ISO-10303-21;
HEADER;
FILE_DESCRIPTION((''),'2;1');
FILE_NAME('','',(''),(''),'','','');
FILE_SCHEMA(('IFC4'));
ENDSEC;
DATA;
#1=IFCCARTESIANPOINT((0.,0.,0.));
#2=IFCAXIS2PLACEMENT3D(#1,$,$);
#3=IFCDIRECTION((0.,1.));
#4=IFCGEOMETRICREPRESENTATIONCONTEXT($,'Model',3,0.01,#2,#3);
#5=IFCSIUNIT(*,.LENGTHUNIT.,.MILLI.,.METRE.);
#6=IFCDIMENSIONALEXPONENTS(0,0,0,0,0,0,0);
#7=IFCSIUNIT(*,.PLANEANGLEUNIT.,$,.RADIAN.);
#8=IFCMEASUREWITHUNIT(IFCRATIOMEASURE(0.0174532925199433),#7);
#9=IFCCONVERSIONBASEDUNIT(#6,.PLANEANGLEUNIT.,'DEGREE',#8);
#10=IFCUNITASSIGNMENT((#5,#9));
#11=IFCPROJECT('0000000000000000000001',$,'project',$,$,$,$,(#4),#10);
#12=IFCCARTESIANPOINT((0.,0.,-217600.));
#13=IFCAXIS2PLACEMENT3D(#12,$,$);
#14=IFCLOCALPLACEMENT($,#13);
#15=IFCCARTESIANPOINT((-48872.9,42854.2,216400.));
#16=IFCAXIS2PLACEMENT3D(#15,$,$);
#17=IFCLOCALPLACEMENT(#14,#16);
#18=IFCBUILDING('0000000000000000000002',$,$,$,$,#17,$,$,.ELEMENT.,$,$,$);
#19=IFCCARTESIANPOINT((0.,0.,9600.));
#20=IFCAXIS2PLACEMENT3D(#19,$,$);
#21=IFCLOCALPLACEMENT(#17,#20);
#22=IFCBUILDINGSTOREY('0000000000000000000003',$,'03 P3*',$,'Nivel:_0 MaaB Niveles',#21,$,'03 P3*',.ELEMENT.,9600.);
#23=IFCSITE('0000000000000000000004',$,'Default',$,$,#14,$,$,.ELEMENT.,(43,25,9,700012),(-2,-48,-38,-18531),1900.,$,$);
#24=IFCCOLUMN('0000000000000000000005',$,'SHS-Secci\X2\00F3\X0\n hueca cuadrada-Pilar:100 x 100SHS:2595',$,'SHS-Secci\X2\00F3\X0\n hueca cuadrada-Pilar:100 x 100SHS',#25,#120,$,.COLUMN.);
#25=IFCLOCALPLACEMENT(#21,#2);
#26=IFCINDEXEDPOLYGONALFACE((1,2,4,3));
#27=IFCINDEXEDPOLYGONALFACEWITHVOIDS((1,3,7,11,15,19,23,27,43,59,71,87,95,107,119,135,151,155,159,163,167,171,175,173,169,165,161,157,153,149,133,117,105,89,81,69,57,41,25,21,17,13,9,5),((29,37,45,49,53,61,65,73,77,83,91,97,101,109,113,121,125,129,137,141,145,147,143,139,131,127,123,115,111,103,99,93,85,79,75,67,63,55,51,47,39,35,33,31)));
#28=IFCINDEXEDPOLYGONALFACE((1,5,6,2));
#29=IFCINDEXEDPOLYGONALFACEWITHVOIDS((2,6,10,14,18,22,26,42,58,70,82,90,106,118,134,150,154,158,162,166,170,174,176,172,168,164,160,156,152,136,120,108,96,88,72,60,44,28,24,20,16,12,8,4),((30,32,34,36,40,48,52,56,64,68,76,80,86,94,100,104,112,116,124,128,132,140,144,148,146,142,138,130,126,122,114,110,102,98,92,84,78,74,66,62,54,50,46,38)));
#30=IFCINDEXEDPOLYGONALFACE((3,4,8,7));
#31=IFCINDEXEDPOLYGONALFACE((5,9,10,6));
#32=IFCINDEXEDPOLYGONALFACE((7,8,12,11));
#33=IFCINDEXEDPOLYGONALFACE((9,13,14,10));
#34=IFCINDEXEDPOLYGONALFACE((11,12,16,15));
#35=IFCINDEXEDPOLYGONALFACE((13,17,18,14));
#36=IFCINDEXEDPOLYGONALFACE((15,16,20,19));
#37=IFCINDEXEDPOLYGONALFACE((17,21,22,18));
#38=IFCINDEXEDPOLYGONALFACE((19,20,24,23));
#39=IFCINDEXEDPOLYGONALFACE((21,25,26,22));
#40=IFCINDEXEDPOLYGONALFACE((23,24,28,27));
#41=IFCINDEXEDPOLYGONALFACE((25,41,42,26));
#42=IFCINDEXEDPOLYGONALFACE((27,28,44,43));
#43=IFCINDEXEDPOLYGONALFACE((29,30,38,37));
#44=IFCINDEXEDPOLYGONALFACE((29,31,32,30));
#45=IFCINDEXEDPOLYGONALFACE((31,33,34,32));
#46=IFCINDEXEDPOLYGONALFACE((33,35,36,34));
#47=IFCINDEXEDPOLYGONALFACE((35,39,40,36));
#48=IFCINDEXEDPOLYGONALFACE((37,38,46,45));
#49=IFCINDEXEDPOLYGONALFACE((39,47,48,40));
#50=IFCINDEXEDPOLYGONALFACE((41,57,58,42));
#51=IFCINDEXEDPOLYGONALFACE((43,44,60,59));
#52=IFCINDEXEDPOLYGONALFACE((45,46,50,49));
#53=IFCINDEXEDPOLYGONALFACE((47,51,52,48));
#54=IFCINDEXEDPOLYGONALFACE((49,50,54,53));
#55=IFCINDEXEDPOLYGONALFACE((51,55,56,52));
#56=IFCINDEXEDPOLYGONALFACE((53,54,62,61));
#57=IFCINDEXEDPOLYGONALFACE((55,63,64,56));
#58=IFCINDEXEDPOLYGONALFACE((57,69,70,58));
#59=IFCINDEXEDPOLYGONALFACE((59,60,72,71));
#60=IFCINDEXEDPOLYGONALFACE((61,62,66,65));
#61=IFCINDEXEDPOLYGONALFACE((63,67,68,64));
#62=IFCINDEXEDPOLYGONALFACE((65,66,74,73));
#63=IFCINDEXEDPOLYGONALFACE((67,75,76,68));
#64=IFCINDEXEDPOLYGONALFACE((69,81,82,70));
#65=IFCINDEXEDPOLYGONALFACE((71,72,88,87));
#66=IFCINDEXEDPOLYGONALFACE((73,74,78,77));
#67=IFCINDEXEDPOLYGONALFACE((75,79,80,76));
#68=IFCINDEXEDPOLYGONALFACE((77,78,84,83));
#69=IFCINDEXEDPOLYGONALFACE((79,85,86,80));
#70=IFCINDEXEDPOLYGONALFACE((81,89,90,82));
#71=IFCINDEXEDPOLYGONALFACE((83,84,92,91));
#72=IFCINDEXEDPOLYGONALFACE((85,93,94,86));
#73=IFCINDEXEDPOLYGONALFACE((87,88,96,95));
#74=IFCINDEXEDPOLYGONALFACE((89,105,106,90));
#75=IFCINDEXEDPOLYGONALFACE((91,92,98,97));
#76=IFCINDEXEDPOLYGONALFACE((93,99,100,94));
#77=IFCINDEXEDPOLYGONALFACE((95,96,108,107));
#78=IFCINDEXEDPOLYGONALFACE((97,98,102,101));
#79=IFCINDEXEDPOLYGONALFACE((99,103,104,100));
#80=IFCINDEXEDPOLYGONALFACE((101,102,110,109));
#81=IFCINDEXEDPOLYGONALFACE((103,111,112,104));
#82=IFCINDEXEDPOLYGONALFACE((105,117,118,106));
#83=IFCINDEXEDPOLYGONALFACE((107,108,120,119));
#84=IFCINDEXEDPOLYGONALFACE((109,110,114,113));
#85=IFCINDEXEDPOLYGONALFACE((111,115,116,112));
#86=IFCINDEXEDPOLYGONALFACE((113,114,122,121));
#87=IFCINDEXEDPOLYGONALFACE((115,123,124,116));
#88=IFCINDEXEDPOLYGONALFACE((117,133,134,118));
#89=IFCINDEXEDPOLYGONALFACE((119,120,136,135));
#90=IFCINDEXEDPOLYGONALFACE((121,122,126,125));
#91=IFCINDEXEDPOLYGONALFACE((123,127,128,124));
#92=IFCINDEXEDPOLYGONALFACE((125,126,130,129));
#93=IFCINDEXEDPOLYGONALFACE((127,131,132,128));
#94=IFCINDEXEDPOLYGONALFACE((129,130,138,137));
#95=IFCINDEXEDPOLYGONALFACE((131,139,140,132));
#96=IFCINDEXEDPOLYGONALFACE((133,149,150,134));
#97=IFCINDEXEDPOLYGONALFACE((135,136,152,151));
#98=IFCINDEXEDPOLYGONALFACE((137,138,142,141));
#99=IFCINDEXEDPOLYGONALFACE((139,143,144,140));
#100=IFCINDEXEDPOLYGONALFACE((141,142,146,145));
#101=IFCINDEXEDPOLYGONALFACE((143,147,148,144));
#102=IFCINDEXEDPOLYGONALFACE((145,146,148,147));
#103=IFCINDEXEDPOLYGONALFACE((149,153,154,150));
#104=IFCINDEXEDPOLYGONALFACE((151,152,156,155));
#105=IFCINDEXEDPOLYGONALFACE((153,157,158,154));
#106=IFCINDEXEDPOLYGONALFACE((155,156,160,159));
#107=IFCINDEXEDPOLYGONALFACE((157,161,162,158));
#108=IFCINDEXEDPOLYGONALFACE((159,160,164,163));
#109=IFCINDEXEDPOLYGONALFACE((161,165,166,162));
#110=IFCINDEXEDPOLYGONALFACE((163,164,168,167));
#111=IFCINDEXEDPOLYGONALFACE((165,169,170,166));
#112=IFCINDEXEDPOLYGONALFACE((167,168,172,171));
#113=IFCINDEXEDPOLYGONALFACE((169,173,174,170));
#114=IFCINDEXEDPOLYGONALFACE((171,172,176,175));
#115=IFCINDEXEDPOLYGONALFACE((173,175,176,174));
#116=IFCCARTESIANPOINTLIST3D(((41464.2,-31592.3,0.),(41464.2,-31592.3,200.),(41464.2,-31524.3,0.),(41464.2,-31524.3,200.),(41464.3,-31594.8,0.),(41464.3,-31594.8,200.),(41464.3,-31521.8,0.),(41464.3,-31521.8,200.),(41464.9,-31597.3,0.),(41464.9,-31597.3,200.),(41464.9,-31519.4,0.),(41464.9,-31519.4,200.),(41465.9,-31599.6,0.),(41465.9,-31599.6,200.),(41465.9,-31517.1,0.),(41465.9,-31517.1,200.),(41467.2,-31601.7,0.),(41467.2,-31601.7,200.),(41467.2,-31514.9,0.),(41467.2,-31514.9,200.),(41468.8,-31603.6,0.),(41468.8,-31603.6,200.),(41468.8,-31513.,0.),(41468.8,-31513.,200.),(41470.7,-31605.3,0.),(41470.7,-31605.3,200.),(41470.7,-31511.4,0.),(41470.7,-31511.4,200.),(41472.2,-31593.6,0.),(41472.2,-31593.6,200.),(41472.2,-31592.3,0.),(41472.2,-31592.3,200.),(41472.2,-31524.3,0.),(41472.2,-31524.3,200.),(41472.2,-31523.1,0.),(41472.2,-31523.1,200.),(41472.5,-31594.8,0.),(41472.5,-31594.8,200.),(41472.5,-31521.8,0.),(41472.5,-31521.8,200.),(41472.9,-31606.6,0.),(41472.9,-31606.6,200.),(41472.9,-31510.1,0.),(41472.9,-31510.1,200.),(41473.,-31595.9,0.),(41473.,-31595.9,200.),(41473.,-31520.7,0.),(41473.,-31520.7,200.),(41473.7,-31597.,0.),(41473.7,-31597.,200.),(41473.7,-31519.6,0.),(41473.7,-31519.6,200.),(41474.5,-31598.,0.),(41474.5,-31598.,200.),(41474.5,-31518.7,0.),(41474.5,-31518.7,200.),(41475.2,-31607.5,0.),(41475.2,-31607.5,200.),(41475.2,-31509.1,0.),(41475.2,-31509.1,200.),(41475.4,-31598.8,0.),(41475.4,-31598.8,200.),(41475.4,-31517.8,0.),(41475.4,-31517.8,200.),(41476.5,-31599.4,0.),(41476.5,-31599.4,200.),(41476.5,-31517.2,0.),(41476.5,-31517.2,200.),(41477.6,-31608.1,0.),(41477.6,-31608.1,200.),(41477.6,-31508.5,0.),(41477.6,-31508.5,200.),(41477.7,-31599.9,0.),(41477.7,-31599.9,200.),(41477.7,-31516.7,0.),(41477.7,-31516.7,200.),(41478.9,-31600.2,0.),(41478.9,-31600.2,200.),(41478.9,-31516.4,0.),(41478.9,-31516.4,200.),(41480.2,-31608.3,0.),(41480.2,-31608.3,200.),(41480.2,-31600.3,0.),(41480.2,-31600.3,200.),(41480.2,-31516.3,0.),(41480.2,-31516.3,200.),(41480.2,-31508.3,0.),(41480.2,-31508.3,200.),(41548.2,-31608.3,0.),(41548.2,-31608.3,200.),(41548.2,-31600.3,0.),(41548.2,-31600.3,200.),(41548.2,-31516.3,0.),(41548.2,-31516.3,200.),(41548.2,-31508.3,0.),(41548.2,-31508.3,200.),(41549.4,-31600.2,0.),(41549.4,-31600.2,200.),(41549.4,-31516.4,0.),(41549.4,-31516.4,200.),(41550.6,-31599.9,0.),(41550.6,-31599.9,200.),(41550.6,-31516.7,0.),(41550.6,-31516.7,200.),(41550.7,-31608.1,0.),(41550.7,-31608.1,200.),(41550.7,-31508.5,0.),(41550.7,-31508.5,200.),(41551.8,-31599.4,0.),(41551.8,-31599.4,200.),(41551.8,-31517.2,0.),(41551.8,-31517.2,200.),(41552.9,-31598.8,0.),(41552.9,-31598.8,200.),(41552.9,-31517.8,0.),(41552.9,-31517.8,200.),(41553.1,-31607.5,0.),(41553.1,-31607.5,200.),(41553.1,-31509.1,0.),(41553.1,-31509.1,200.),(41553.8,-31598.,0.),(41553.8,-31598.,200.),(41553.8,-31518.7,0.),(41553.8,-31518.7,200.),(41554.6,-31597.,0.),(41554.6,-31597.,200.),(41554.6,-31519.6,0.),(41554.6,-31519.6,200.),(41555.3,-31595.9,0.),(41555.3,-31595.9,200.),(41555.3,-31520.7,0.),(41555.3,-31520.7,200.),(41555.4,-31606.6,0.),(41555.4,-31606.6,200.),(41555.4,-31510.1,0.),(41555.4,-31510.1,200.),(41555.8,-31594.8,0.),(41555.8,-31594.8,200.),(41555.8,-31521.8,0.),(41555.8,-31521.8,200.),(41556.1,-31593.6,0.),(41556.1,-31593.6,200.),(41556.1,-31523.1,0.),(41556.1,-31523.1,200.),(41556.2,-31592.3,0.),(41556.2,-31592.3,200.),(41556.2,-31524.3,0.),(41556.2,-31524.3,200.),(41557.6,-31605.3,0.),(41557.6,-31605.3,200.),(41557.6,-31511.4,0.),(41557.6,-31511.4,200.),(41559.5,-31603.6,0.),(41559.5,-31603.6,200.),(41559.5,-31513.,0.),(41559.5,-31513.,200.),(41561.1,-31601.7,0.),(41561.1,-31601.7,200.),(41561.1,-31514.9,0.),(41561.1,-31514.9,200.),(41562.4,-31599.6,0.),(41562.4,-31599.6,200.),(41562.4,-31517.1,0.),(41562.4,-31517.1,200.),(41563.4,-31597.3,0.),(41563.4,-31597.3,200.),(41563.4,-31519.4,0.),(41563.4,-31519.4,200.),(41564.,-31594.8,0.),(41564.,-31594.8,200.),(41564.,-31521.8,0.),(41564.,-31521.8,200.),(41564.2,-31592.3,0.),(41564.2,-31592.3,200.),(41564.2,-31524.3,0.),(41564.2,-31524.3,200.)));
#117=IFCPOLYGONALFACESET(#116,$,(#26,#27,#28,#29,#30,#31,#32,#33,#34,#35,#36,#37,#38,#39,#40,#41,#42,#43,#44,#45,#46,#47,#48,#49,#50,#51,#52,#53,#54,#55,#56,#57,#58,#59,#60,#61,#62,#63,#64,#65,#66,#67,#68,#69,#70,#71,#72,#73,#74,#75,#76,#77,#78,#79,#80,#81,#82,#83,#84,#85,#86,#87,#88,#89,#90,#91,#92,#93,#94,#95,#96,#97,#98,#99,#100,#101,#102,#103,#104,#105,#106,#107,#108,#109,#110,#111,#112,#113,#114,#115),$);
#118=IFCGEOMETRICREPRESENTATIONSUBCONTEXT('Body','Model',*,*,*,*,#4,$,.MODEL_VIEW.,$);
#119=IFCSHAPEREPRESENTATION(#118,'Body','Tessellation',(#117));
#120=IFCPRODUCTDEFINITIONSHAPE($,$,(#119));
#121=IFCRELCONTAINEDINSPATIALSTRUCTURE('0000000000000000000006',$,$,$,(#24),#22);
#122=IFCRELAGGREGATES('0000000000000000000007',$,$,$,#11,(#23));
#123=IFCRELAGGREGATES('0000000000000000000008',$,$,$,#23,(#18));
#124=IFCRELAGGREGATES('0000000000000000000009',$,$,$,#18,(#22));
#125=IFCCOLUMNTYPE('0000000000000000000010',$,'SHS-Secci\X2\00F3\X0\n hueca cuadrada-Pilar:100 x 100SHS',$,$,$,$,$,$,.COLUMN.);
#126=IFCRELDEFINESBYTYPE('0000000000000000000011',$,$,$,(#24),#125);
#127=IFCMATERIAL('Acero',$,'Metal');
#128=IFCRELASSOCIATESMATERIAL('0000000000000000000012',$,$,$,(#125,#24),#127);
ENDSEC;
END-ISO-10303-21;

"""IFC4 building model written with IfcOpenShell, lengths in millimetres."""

from ifc_helpers import new_model, entity, si_unit, converted_unit, direction, frame, origin, place, context, subcontext, project, spatial, indexed_curve, outline, extrude, source, transform, mapped, material, type_object, type_shapes, element, save


model = new_model("IFC4")

# Units and contexts
model_context = context("Model", 3, precision=0.01, world=origin(), true_north=direction((0.0, 1.0)))
body_context = subcontext(model_context, "Body", "Model", "MODEL_VIEW")
ifc_project = project(units=[si_unit("LENGTHUNIT", "METRE", prefix="MILLI"), converted_unit("PLANEANGLEUNIT", "DEGREE", entity("IfcRatioMeasure", 0.0174532925199433), si_unit("PLANEANGLEUNIT", "RADIAN"), dimensions=[0, 0, 0, 0, 0, 0, 0])], contexts=[model_context])

# Site, building, storey
site_placement = place(None, frame((0.0, 0.0, -217600.0)))
site = spatial("IfcSite", under=ifc_project, at=site_placement, Name="Default", CompositionType="ELEMENT", RefLatitude=(43, 25, 9, 700012), RefLongitude=(-2, -48, -38, -18531), RefElevation=1900.0)
building_placement = place(site_placement, frame((-48872.9, 42854.2, 216400.0)))
building = spatial("IfcBuilding", under=site, at=building_placement, CompositionType="ELEMENT")
storey_placement = place(building_placement, frame((0.0, 0.0, 9600.0)))
storey = spatial("IfcBuildingStorey", under=building, at=storey_placement, Name="03 P3*", ObjectType="Nivel:_0 MaaB Niveles", LongName="03 P3*", CompositionType="ELEMENT", Elevation=9600.0)

# Column
ifc_material_1 = material(Name="Acero", Category="Metal")
column_type_1 = type_object("IfcColumnType", Name="SHS-Sección hueca cuadrada-Pilar:100 x 100SHS", PredefinedType="COLUMN", material=ifc_material_1)
shared_shape_1 = source(origin(), body_context, "Body", "SweptSolid", [
    extrude(outline(indexed_curve([(-34.0, -50.0), (34.0, -50.0), (36.5, -49.8), (38.9, -49.2), (41.3, -48.3), (43.4, -46.9), (45.3, -45.3), (46.9, -43.4), (48.3, -41.3), (49.2, -38.9), (49.8, -36.5), (50.0, -34.0), (50.0, 34.0), (49.8, 36.5), (49.2, 38.9), (48.3, 41.3), (46.9, 43.4), (45.3, 45.3), (43.4, 46.9), (41.3, 48.3), (38.9, 49.2), (36.5, 49.8), (34.0, 50.0), (-34.0, 50.0), (-36.5, 49.8), (-38.9, 49.2), (-41.3, 48.3), (-43.4, 46.9), (-45.3, 45.3), (-46.9, 43.4), (-48.3, 41.3), (-49.2, 38.9), (-49.8, 36.5), (-50.0, 34.0), (-50.0, -34.0), (-49.8, -36.5), (-49.2, -38.9), (-48.3, -41.3), (-46.9, -43.4), (-45.3, -45.3), (-43.4, -46.9), (-41.3, -48.3), (-38.9, -49.2), (-36.5, -49.8), (-34.0, -50.0)], self_intersect=False), holes=[indexed_curve([(-42.0, 34.0), (-41.9, 35.3), (-41.6, 36.5), (-41.1, 37.6), (-40.5, 38.7), (-39.7, 39.7), (-38.7, 40.5), (-37.6, 41.1), (-36.5, 41.6), (-35.3, 41.9), (-34.0, 42.0), (34.0, 42.0), (35.3, 41.9), (36.5, 41.6), (37.6, 41.1), (38.7, 40.5), (39.7, 39.7), (40.5, 38.7), (41.1, 37.6), (41.6, 36.5), (41.9, 35.3), (42.0, 34.0), (42.0, -34.0), (41.9, -35.3), (41.6, -36.5), (41.1, -37.6), (40.5, -38.7), (39.7, -39.7), (38.7, -40.5), (37.6, -41.1), (36.5, -41.6), (35.3, -41.9), (34.0, -42.0), (-34.0, -42.0), (-35.3, -41.9), (-36.5, -41.6), (-37.6, -41.1), (-38.7, -40.5), (-39.7, -39.7), (-40.5, -38.7), (-41.1, -37.6), (-41.6, -36.5), (-41.9, -35.3), (-42.0, -34.0), (-42.0, 34.0)], self_intersect=False)]), frame((0.0, 0.0, 9600.0), z_axis=(0.0, 0.0, 1.0), x_axis=(0.0, 1.0, 0.0)), (0.0, 0.0, 1.0), 200.0),
])
type_shapes(column_type_1, [shared_shape_1])
column_1_placement = place(storey_placement, frame((41514.2, -31558.3, -9600.0), z_axis=(0.0, 0.0, 1.0), x_axis=(0.0, -1.0, 0.0)))
element("IfcColumn", 1, at=column_1_placement, inside=storey, type_object=column_type_1, material=ifc_material_1, Name="SHS-Sección hueca cuadrada-Pilar:100 x 100SHS:2595", ObjectType="SHS-Sección hueca cuadrada-Pilar:100 x 100SHS", PredefinedType="COLUMN", context=body_context, shape_type="MappedRepresentation", body=[
    mapped(shared_shape_1, transform((0.0, 0.0, 0.0), scale=1.0)),
])

save(model, "model.ifc")
